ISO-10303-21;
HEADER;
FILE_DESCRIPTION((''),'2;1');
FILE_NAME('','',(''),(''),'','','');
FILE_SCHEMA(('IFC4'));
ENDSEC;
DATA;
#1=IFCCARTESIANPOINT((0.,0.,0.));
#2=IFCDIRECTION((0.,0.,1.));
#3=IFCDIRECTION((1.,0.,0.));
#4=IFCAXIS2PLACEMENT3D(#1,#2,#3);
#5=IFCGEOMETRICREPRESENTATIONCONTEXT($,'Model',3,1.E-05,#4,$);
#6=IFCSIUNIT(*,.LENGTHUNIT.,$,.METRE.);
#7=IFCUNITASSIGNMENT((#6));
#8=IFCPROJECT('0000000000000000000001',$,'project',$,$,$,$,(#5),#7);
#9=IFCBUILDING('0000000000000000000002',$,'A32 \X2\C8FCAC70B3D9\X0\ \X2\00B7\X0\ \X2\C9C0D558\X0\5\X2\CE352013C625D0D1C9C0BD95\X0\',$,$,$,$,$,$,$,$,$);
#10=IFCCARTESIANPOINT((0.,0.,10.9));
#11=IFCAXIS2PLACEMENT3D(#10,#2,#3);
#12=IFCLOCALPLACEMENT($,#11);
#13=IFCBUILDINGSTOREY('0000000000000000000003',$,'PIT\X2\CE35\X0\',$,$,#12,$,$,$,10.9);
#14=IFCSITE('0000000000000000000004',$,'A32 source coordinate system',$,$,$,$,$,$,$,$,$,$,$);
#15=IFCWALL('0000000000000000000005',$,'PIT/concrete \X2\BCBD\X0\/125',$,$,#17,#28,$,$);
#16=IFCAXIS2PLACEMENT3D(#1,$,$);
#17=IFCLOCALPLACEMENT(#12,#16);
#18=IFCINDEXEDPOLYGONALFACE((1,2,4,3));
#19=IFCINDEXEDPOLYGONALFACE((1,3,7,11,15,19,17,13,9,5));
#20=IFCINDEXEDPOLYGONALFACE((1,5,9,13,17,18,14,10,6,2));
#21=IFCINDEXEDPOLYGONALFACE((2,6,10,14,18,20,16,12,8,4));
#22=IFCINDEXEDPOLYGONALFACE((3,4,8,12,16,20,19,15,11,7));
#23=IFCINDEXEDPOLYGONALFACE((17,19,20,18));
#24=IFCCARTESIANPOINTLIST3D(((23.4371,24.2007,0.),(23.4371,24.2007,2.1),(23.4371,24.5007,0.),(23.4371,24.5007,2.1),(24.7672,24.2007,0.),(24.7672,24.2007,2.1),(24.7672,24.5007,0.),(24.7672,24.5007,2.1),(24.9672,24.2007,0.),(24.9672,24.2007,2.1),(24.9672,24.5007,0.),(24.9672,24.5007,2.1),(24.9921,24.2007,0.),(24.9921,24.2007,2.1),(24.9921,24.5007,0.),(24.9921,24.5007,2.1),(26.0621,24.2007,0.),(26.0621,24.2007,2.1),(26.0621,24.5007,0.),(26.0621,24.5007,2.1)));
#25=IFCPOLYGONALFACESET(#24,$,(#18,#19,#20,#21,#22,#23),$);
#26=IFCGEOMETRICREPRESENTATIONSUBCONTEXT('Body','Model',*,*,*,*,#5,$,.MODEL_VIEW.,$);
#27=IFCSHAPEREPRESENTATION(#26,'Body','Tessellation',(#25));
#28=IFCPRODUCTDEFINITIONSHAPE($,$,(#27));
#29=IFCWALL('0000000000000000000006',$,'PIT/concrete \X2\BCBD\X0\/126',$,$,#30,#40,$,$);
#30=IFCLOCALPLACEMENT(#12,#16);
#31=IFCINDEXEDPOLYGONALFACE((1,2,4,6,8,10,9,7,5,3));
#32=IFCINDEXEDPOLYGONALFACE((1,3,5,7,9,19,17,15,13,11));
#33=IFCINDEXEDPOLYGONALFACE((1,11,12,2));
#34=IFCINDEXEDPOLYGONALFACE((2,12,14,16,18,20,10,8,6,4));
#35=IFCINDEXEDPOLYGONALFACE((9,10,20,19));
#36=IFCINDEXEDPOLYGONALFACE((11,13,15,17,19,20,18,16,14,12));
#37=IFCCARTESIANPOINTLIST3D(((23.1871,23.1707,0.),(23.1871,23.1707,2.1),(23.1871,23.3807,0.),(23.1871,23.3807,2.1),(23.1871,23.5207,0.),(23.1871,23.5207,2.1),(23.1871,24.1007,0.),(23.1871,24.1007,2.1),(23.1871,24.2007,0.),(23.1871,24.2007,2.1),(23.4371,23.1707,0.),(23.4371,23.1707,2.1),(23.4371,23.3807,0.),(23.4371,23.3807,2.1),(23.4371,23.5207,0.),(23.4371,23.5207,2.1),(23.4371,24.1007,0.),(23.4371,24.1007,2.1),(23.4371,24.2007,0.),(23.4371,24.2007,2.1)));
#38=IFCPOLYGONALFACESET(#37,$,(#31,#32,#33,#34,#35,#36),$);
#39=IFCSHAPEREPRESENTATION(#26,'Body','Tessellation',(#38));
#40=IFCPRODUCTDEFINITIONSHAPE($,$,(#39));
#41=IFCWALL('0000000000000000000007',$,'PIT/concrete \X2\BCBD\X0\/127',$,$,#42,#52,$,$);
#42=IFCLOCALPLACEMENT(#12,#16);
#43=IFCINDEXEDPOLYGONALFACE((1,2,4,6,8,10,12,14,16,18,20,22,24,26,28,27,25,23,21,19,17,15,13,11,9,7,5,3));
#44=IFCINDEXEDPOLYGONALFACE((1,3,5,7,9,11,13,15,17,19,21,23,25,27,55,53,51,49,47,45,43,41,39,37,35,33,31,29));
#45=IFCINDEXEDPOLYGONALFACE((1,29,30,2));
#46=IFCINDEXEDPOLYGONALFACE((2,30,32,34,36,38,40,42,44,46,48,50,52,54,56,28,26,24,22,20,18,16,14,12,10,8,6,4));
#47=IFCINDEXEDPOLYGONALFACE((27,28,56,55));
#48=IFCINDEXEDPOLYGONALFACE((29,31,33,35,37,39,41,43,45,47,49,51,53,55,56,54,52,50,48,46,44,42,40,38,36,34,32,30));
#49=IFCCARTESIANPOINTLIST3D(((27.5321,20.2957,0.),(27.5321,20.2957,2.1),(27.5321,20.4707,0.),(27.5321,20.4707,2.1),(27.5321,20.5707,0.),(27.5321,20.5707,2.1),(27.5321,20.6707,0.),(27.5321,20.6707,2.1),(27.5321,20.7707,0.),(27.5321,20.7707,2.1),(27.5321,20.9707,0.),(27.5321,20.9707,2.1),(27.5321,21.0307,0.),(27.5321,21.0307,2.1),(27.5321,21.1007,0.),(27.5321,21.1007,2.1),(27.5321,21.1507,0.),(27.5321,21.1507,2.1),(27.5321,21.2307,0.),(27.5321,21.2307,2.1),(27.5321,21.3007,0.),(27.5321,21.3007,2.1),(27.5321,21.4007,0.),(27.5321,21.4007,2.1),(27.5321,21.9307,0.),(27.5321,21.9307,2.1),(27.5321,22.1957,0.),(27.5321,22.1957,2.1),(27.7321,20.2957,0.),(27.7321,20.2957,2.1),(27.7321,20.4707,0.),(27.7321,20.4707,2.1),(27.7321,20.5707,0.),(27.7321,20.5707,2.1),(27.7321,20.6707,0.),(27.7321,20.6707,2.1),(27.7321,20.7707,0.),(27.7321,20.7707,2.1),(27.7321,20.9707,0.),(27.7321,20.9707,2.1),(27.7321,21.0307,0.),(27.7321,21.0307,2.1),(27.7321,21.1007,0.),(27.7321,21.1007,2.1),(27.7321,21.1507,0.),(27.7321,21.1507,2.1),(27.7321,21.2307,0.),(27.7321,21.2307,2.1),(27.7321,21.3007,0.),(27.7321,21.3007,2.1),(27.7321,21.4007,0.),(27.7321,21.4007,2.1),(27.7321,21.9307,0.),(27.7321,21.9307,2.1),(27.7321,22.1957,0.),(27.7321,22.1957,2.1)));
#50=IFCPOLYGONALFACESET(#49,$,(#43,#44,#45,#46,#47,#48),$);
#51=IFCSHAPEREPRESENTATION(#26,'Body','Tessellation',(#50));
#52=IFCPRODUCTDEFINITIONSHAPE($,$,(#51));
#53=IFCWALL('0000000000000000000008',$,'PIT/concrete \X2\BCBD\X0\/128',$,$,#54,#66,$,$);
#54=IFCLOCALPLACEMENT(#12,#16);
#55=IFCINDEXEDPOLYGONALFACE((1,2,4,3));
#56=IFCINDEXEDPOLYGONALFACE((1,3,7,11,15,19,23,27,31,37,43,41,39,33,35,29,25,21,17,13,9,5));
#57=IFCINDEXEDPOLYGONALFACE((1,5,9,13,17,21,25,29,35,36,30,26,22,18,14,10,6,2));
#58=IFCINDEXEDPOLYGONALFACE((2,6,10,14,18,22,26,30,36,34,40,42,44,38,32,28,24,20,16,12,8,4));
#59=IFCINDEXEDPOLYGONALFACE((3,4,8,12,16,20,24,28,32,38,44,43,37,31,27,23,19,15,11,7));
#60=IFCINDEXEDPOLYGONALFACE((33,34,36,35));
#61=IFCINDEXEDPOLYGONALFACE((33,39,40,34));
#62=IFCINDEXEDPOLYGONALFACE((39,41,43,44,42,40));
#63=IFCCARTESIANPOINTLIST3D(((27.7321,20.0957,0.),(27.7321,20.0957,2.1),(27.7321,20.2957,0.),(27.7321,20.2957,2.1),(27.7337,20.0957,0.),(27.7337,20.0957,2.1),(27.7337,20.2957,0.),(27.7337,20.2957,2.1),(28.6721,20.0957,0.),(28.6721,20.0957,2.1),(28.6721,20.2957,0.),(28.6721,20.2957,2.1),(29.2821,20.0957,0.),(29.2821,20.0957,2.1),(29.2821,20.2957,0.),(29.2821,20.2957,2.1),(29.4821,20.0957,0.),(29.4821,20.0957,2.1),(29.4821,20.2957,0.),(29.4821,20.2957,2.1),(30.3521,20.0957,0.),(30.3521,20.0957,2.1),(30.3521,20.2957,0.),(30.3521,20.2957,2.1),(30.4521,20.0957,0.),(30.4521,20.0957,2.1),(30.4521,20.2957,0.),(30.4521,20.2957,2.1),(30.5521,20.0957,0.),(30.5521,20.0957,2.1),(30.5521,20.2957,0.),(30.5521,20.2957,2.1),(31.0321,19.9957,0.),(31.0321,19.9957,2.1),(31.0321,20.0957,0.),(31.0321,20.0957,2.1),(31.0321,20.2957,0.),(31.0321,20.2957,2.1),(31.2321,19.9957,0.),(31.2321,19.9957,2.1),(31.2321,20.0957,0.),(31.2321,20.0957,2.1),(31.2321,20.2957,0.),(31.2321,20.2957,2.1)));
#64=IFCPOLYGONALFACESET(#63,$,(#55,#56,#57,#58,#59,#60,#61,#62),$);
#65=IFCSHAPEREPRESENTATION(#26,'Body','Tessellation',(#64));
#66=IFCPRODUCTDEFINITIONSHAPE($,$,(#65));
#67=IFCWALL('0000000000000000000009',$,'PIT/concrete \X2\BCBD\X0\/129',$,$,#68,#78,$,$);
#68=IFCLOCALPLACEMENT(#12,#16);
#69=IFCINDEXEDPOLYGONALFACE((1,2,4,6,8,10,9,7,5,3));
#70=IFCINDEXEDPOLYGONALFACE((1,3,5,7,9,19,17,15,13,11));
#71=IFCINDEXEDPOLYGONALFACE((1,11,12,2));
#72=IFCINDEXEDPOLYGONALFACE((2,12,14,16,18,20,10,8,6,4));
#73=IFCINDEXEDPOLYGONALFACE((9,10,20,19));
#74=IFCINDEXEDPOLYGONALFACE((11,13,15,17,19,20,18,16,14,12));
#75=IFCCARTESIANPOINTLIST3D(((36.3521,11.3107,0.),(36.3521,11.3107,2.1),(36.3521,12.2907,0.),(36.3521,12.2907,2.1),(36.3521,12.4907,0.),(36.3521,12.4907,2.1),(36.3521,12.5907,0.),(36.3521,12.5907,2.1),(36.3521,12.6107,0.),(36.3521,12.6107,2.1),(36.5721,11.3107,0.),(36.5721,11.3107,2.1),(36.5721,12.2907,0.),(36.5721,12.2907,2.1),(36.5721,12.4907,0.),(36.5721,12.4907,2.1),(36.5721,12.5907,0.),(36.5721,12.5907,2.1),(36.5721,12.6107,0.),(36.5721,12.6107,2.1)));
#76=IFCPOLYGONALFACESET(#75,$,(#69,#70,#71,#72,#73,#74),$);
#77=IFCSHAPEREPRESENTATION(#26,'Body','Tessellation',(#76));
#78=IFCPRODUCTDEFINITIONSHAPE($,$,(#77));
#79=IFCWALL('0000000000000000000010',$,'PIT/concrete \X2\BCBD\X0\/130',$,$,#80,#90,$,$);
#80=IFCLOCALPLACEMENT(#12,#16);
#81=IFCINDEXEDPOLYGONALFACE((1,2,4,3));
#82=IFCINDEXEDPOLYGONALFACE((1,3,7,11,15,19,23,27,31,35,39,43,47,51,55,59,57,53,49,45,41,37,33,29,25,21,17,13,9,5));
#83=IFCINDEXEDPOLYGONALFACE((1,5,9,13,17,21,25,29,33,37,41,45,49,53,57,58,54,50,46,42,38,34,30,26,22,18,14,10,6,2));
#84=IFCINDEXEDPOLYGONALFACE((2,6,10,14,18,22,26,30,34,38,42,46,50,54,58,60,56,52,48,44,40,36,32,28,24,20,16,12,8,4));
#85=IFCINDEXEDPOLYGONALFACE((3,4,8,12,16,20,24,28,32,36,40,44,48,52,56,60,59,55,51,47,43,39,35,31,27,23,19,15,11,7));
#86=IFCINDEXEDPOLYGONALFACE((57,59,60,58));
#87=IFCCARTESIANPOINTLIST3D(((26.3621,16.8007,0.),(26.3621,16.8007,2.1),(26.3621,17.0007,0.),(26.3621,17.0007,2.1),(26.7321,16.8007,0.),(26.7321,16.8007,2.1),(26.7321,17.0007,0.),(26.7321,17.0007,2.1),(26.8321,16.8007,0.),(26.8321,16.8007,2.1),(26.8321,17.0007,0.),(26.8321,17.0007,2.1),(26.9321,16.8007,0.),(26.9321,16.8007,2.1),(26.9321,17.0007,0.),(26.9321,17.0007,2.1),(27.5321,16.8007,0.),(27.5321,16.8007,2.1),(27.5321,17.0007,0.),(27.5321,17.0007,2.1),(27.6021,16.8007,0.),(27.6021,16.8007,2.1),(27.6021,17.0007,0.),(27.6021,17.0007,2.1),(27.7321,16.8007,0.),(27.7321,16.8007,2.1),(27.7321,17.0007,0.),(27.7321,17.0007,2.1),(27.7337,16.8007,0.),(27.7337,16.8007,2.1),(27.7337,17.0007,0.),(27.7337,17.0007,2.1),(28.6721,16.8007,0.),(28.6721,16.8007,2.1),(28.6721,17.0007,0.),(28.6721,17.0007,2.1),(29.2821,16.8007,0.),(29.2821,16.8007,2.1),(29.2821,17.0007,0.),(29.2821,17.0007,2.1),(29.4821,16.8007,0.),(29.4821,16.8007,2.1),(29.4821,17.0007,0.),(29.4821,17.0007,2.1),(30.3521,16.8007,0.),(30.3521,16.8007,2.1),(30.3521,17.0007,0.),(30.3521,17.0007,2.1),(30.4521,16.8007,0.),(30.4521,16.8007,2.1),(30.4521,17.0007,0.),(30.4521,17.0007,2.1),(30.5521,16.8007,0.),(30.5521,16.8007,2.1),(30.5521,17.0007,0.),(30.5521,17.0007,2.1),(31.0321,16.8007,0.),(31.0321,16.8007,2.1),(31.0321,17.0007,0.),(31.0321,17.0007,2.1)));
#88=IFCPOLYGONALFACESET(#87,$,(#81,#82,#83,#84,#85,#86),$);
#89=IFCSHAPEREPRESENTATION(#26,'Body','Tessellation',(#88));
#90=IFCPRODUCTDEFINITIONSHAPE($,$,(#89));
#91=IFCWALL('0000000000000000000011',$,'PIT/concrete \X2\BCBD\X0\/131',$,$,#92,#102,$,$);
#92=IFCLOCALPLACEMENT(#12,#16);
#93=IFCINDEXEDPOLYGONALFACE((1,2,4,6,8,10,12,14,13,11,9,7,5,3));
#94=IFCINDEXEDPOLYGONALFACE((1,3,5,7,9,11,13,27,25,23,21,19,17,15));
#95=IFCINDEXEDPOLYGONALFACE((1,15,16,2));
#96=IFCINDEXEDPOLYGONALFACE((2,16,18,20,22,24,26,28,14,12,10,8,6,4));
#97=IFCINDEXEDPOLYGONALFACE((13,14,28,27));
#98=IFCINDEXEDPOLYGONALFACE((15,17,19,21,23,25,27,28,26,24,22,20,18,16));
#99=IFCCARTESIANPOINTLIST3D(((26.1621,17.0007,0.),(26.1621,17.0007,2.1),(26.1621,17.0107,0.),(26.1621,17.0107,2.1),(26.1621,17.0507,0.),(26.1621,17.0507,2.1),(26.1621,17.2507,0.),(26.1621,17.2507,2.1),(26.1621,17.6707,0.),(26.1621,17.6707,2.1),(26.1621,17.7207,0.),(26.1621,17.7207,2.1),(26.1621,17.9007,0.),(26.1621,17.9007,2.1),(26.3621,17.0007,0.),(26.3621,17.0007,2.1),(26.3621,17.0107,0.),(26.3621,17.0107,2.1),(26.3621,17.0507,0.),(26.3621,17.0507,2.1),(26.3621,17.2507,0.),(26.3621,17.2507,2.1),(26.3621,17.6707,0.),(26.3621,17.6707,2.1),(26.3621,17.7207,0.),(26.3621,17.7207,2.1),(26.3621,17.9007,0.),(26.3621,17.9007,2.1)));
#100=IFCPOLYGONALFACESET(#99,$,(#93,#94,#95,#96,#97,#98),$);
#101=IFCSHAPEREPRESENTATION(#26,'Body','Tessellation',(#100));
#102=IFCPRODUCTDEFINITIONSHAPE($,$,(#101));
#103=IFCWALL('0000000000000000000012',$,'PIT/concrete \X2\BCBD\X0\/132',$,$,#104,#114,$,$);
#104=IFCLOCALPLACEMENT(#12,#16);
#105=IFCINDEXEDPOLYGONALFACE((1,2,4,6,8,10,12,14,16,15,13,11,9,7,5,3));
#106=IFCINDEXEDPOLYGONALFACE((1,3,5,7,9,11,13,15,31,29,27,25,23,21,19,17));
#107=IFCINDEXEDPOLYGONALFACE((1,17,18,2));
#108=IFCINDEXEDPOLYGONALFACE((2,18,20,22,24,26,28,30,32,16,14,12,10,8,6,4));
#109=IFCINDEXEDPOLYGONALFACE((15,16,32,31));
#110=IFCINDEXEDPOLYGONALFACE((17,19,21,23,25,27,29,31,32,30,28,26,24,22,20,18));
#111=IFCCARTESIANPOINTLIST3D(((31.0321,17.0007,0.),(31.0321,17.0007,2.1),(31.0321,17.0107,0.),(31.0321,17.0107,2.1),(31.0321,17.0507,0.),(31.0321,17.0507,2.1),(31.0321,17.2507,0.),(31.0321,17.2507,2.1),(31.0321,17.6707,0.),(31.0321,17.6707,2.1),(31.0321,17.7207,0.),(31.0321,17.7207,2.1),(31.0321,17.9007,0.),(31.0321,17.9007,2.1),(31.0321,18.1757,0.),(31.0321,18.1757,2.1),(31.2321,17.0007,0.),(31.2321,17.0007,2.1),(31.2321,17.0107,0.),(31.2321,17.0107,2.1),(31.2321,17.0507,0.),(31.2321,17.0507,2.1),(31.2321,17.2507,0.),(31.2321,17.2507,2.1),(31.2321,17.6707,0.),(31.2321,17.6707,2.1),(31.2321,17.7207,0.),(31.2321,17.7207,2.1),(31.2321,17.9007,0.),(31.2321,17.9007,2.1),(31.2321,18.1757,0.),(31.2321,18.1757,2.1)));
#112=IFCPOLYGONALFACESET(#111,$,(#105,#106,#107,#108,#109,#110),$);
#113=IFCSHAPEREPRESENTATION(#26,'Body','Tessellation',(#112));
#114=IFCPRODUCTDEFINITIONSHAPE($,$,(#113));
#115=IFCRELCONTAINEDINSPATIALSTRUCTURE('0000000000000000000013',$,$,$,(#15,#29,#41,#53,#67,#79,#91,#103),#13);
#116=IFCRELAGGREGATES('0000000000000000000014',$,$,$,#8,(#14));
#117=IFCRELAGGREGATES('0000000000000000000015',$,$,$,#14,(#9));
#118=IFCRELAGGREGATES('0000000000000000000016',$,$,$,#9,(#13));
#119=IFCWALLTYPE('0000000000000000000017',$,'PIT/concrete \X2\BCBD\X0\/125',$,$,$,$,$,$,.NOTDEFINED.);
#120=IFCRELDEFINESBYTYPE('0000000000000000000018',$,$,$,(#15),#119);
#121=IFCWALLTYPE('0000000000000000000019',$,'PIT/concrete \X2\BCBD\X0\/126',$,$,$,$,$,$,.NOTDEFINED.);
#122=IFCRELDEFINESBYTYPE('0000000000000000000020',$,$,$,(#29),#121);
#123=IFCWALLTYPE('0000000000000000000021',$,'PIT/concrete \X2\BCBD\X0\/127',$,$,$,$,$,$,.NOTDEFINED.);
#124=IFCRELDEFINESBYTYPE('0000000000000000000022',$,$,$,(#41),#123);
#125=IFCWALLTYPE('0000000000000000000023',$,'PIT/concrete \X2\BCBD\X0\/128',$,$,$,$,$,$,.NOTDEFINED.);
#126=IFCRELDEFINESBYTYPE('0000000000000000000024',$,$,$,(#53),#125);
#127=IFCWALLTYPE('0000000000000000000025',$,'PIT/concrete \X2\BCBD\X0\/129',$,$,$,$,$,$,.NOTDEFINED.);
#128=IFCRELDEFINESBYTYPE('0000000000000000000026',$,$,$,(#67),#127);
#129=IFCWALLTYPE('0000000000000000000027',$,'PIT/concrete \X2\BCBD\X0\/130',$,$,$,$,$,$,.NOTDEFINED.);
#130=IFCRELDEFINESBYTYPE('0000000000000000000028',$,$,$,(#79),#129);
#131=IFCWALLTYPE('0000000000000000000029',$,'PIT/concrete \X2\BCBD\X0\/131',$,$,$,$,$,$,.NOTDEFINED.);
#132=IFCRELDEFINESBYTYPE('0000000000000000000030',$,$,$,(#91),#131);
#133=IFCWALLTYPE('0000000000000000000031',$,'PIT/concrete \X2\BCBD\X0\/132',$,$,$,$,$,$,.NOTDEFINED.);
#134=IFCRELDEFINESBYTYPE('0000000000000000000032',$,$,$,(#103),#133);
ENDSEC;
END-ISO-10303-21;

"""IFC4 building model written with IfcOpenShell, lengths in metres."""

from ifc_helpers import new_model, si_unit, frame, origin, origin_with_axes, place, context, subcontext, project, spatial, polyline, outline, extrude, source, transform, mapped, type_object, type_shapes, element, save


model = new_model("IFC4")

# Units and contexts
model_context = context("Model", 3, precision=1e-05, world=origin_with_axes())
body_context = subcontext(model_context, "Body", "Model", "MODEL_VIEW")
ifc_project = project(units=[si_unit("LENGTHUNIT", "METRE")], contexts=[model_context])

# Site, building, storey
site = spatial("IfcSite", under=ifc_project, Name="A32 source coordinate system")
building = spatial("IfcBuilding", under=site, Name="A32 주거동 · 지하5층–옥탑지붕")
storey_placement = place(None, frame((0.0, 0.0, 10.9), z_axis=(0.0, 0.0, 1.0), x_axis=(1.0, 0.0, 0.0)))
storey = spatial("IfcBuildingStorey", under=building, at=storey_placement, Name="PIT층", Elevation=10.9)

# Walls
wall_type_1 = type_object("IfcWallType", Name="PIT/concrete 벽/125", PredefinedType="NOTDEFINED")
shared_shape_1 = source(origin(), body_context, "Body", "SweptSolid", [
    extrude(outline(polyline([(24.7672, 24.2007), (23.4371, 24.2007), (23.4371, 24.5007), (24.7672, 24.5007), (24.9672, 24.5007), (24.9921, 24.5007), (26.0621, 24.5007), (26.0621, 24.2007), (24.9921, 24.2007), (24.9672, 24.2007), (24.7672, 24.2007)])), origin(), (0.0, 0.0, 1.0), 2.1),
])
type_shapes(wall_type_1, [shared_shape_1])
wall_1_placement = place(storey_placement, origin_with_axes())
element("IfcWall", 1, at=wall_1_placement, inside=storey, type_object=wall_type_1, Name="PIT/concrete 벽/125", context=body_context, shape_type="MappedRepresentation", body=[
    mapped(shared_shape_1, transform((0.0, 0.0, 0.0), scale=1.0)),
])
wall_type_2 = type_object("IfcWallType", Name="PIT/concrete 벽/126", PredefinedType="NOTDEFINED")
shared_shape_2 = source(origin(), body_context, "Body", "SweptSolid", [
    extrude(outline(polyline([(23.4371, 23.3807), (23.4371, 23.1707), (23.1871, 23.1707), (23.1871, 23.3807), (23.1871, 23.5207), (23.1871, 24.1007), (23.1871, 24.2007), (23.4371, 24.2007), (23.4371, 24.1007), (23.4371, 23.5207), (23.4371, 23.3807)])), origin(), (0.0, 0.0, 1.0), 2.1),
])
type_shapes(wall_type_2, [shared_shape_2])
wall_2_placement = place(storey_placement, origin_with_axes())
element("IfcWall", 2, at=wall_2_placement, inside=storey, type_object=wall_type_2, Name="PIT/concrete 벽/126", context=body_context, shape_type="MappedRepresentation", body=[
    mapped(shared_shape_2, transform((0.0, 0.0, 0.0), scale=1.0)),
])
wall_type_3 = type_object("IfcWallType", Name="PIT/concrete 벽/127", PredefinedType="NOTDEFINED")
shared_shape_3 = source(origin(), body_context, "Body", "SweptSolid", [
    extrude(outline(polyline([(27.5321, 20.6707), (27.5321, 20.7707), (27.5321, 20.9707), (27.5321, 21.0307), (27.5321, 21.1007), (27.5321, 21.1507), (27.5321, 21.2307), (27.5321, 21.3007), (27.5321, 21.4007), (27.5321, 21.9307), (27.5321, 22.1957), (27.7321, 22.1957), (27.7321, 21.9307), (27.7321, 21.4007), (27.7321, 21.3007), (27.7321, 21.2307), (27.7321, 21.1507), (27.7321, 21.1007), (27.7321, 21.0307), (27.7321, 20.9707), (27.7321, 20.7707), (27.7321, 20.6707), (27.7321, 20.5707), (27.7321, 20.4707), (27.7321, 20.2957), (27.5321, 20.2957), (27.5321, 20.4707), (27.5321, 20.5707), (27.5321, 20.6707)])), origin(), (0.0, 0.0, 1.0), 2.1),
])
type_shapes(wall_type_3, [shared_shape_3])
wall_3_placement = place(storey_placement, origin_with_axes())
element("IfcWall", 3, at=wall_3_placement, inside=storey, type_object=wall_type_3, Name="PIT/concrete 벽/127", context=body_context, shape_type="MappedRepresentation", body=[
    mapped(shared_shape_3, transform((0.0, 0.0, 0.0), scale=1.0)),
])
wall_type_4 = type_object("IfcWallType", Name="PIT/concrete 벽/128", PredefinedType="NOTDEFINED")
shared_shape_4 = source(origin(), body_context, "Body", "SweptSolid", [
    extrude(outline(polyline([(29.2821, 20.2957), (29.4821, 20.2957), (30.3521, 20.2957), (30.4521, 20.2957), (30.5521, 20.2957), (31.0321, 20.2957), (31.2321, 20.2957), (31.2321, 20.0957), (31.2321, 19.9957), (31.0321, 19.9957), (31.0321, 20.0957), (30.5521, 20.0957), (30.4521, 20.0957), (30.3521, 20.0957), (29.4821, 20.0957), (29.2821, 20.0957), (28.6721, 20.0957), (27.7337, 20.0957), (27.7321, 20.0957), (27.7321, 20.2957), (27.7337, 20.2957), (28.6721, 20.2957), (29.2821, 20.2957)])), origin(), (0.0, 0.0, 1.0), 2.1),
])
type_shapes(wall_type_4, [shared_shape_4])
wall_4_placement = place(storey_placement, origin_with_axes())
element("IfcWall", 4, at=wall_4_placement, inside=storey, type_object=wall_type_4, Name="PIT/concrete 벽/128", context=body_context, shape_type="MappedRepresentation", body=[
    mapped(shared_shape_4, transform((0.0, 0.0, 0.0), scale=1.0)),
])
wall_type_5 = type_object("IfcWallType", Name="PIT/concrete 벽/129", PredefinedType="NOTDEFINED")
shared_shape_5 = source(origin(), body_context, "Body", "SweptSolid", [
    extrude(outline(polyline([(36.3521, 12.2907), (36.3521, 12.4907), (36.3521, 12.5907), (36.3521, 12.6107), (36.5721, 12.6107), (36.5721, 12.5907), (36.5721, 12.4907), (36.5721, 12.2907), (36.5721, 11.3107), (36.3521, 11.3107), (36.3521, 12.2907)])), origin(), (0.0, 0.0, 1.0), 2.1),
])
type_shapes(wall_type_5, [shared_shape_5])
wall_5_placement = place(storey_placement, origin_with_axes())
element("IfcWall", 5, at=wall_5_placement, inside=storey, type_object=wall_type_5, Name="PIT/concrete 벽/129", context=body_context, shape_type="MappedRepresentation", body=[
    mapped(shared_shape_5, transform((0.0, 0.0, 0.0), scale=1.0)),
])
wall_type_6 = type_object("IfcWallType", Name="PIT/concrete 벽/130", PredefinedType="NOTDEFINED")
shared_shape_6 = source(origin(), body_context, "Body", "SweptSolid", [
    extrude(outline(polyline([(26.9321, 17.0007), (27.5321, 17.0007), (27.6021, 17.0007), (27.7321, 17.0007), (27.7337, 17.0007), (28.6721, 17.0007), (29.2821, 17.0007), (29.4821, 17.0007), (30.3521, 17.0007), (30.4521, 17.0007), (30.5521, 17.0007), (31.0321, 17.0007), (31.0321, 16.8007), (30.5521, 16.8007), (30.4521, 16.8007), (30.3521, 16.8007), (29.4821, 16.8007), (29.2821, 16.8007), (28.6721, 16.8007), (27.7337, 16.8007), (27.7321, 16.8007), (27.6021, 16.8007), (27.5321, 16.8007), (26.9321, 16.8007), (26.8321, 16.8007), (26.7321, 16.8007), (26.3621, 16.8007), (26.3621, 17.0007), (26.7321, 17.0007), (26.8321, 17.0007), (26.9321, 17.0007)])), origin(), (0.0, 0.0, 1.0), 2.1),
])
type_shapes(wall_type_6, [shared_shape_6])
wall_6_placement = place(storey_placement, origin_with_axes())
element("IfcWall", 6, at=wall_6_placement, inside=storey, type_object=wall_type_6, Name="PIT/concrete 벽/130", context=body_context, shape_type="MappedRepresentation", body=[
    mapped(shared_shape_6, transform((0.0, 0.0, 0.0), scale=1.0)),
])
wall_type_7 = type_object("IfcWallType", Name="PIT/concrete 벽/131", PredefinedType="NOTDEFINED")
shared_shape_7 = source(origin(), body_context, "Body", "SweptSolid", [
    extrude(outline(polyline([(26.1621, 17.0507), (26.1621, 17.2507), (26.1621, 17.6707), (26.1621, 17.7207), (26.1621, 17.9007), (26.3621, 17.9007), (26.3621, 17.7207), (26.3621, 17.6707), (26.3621, 17.2507), (26.3621, 17.0507), (26.3621, 17.0107), (26.3621, 17.0007), (26.1621, 17.0007), (26.1621, 17.0107), (26.1621, 17.0507)])), origin(), (0.0, 0.0, 1.0), 2.1),
])
type_shapes(wall_type_7, [shared_shape_7])
wall_7_placement = place(storey_placement, origin_with_axes())
element("IfcWall", 7, at=wall_7_placement, inside=storey, type_object=wall_type_7, Name="PIT/concrete 벽/131", context=body_context, shape_type="MappedRepresentation", body=[
    mapped(shared_shape_7, transform((0.0, 0.0, 0.0), scale=1.0)),
])
wall_type_8 = type_object("IfcWallType", Name="PIT/concrete 벽/132", PredefinedType="NOTDEFINED")
shared_shape_8 = source(origin(), body_context, "Body", "SweptSolid", [
    extrude(outline(polyline([(31.0321, 17.2507), (31.0321, 17.6707), (31.0321, 17.7207), (31.0321, 17.9007), (31.0321, 18.1757), (31.2321, 18.1757), (31.2321, 17.9007), (31.2321, 17.7207), (31.2321, 17.6707), (31.2321, 17.2507), (31.2321, 17.0507), (31.2321, 17.0107), (31.2321, 17.0007), (31.0321, 17.0007), (31.0321, 17.0107), (31.0321, 17.0507), (31.0321, 17.2507)])), origin(), (0.0, 0.0, 1.0), 2.1),
])
type_shapes(wall_type_8, [shared_shape_8])
wall_8_placement = place(storey_placement, origin_with_axes())
element("IfcWall", 8, at=wall_8_placement, inside=storey, type_object=wall_type_8, Name="PIT/concrete 벽/132", context=body_context, shape_type="MappedRepresentation", body=[
    mapped(shared_shape_8, transform((0.0, 0.0, 0.0), scale=1.0)),
])

save(model, "model.ifc")
